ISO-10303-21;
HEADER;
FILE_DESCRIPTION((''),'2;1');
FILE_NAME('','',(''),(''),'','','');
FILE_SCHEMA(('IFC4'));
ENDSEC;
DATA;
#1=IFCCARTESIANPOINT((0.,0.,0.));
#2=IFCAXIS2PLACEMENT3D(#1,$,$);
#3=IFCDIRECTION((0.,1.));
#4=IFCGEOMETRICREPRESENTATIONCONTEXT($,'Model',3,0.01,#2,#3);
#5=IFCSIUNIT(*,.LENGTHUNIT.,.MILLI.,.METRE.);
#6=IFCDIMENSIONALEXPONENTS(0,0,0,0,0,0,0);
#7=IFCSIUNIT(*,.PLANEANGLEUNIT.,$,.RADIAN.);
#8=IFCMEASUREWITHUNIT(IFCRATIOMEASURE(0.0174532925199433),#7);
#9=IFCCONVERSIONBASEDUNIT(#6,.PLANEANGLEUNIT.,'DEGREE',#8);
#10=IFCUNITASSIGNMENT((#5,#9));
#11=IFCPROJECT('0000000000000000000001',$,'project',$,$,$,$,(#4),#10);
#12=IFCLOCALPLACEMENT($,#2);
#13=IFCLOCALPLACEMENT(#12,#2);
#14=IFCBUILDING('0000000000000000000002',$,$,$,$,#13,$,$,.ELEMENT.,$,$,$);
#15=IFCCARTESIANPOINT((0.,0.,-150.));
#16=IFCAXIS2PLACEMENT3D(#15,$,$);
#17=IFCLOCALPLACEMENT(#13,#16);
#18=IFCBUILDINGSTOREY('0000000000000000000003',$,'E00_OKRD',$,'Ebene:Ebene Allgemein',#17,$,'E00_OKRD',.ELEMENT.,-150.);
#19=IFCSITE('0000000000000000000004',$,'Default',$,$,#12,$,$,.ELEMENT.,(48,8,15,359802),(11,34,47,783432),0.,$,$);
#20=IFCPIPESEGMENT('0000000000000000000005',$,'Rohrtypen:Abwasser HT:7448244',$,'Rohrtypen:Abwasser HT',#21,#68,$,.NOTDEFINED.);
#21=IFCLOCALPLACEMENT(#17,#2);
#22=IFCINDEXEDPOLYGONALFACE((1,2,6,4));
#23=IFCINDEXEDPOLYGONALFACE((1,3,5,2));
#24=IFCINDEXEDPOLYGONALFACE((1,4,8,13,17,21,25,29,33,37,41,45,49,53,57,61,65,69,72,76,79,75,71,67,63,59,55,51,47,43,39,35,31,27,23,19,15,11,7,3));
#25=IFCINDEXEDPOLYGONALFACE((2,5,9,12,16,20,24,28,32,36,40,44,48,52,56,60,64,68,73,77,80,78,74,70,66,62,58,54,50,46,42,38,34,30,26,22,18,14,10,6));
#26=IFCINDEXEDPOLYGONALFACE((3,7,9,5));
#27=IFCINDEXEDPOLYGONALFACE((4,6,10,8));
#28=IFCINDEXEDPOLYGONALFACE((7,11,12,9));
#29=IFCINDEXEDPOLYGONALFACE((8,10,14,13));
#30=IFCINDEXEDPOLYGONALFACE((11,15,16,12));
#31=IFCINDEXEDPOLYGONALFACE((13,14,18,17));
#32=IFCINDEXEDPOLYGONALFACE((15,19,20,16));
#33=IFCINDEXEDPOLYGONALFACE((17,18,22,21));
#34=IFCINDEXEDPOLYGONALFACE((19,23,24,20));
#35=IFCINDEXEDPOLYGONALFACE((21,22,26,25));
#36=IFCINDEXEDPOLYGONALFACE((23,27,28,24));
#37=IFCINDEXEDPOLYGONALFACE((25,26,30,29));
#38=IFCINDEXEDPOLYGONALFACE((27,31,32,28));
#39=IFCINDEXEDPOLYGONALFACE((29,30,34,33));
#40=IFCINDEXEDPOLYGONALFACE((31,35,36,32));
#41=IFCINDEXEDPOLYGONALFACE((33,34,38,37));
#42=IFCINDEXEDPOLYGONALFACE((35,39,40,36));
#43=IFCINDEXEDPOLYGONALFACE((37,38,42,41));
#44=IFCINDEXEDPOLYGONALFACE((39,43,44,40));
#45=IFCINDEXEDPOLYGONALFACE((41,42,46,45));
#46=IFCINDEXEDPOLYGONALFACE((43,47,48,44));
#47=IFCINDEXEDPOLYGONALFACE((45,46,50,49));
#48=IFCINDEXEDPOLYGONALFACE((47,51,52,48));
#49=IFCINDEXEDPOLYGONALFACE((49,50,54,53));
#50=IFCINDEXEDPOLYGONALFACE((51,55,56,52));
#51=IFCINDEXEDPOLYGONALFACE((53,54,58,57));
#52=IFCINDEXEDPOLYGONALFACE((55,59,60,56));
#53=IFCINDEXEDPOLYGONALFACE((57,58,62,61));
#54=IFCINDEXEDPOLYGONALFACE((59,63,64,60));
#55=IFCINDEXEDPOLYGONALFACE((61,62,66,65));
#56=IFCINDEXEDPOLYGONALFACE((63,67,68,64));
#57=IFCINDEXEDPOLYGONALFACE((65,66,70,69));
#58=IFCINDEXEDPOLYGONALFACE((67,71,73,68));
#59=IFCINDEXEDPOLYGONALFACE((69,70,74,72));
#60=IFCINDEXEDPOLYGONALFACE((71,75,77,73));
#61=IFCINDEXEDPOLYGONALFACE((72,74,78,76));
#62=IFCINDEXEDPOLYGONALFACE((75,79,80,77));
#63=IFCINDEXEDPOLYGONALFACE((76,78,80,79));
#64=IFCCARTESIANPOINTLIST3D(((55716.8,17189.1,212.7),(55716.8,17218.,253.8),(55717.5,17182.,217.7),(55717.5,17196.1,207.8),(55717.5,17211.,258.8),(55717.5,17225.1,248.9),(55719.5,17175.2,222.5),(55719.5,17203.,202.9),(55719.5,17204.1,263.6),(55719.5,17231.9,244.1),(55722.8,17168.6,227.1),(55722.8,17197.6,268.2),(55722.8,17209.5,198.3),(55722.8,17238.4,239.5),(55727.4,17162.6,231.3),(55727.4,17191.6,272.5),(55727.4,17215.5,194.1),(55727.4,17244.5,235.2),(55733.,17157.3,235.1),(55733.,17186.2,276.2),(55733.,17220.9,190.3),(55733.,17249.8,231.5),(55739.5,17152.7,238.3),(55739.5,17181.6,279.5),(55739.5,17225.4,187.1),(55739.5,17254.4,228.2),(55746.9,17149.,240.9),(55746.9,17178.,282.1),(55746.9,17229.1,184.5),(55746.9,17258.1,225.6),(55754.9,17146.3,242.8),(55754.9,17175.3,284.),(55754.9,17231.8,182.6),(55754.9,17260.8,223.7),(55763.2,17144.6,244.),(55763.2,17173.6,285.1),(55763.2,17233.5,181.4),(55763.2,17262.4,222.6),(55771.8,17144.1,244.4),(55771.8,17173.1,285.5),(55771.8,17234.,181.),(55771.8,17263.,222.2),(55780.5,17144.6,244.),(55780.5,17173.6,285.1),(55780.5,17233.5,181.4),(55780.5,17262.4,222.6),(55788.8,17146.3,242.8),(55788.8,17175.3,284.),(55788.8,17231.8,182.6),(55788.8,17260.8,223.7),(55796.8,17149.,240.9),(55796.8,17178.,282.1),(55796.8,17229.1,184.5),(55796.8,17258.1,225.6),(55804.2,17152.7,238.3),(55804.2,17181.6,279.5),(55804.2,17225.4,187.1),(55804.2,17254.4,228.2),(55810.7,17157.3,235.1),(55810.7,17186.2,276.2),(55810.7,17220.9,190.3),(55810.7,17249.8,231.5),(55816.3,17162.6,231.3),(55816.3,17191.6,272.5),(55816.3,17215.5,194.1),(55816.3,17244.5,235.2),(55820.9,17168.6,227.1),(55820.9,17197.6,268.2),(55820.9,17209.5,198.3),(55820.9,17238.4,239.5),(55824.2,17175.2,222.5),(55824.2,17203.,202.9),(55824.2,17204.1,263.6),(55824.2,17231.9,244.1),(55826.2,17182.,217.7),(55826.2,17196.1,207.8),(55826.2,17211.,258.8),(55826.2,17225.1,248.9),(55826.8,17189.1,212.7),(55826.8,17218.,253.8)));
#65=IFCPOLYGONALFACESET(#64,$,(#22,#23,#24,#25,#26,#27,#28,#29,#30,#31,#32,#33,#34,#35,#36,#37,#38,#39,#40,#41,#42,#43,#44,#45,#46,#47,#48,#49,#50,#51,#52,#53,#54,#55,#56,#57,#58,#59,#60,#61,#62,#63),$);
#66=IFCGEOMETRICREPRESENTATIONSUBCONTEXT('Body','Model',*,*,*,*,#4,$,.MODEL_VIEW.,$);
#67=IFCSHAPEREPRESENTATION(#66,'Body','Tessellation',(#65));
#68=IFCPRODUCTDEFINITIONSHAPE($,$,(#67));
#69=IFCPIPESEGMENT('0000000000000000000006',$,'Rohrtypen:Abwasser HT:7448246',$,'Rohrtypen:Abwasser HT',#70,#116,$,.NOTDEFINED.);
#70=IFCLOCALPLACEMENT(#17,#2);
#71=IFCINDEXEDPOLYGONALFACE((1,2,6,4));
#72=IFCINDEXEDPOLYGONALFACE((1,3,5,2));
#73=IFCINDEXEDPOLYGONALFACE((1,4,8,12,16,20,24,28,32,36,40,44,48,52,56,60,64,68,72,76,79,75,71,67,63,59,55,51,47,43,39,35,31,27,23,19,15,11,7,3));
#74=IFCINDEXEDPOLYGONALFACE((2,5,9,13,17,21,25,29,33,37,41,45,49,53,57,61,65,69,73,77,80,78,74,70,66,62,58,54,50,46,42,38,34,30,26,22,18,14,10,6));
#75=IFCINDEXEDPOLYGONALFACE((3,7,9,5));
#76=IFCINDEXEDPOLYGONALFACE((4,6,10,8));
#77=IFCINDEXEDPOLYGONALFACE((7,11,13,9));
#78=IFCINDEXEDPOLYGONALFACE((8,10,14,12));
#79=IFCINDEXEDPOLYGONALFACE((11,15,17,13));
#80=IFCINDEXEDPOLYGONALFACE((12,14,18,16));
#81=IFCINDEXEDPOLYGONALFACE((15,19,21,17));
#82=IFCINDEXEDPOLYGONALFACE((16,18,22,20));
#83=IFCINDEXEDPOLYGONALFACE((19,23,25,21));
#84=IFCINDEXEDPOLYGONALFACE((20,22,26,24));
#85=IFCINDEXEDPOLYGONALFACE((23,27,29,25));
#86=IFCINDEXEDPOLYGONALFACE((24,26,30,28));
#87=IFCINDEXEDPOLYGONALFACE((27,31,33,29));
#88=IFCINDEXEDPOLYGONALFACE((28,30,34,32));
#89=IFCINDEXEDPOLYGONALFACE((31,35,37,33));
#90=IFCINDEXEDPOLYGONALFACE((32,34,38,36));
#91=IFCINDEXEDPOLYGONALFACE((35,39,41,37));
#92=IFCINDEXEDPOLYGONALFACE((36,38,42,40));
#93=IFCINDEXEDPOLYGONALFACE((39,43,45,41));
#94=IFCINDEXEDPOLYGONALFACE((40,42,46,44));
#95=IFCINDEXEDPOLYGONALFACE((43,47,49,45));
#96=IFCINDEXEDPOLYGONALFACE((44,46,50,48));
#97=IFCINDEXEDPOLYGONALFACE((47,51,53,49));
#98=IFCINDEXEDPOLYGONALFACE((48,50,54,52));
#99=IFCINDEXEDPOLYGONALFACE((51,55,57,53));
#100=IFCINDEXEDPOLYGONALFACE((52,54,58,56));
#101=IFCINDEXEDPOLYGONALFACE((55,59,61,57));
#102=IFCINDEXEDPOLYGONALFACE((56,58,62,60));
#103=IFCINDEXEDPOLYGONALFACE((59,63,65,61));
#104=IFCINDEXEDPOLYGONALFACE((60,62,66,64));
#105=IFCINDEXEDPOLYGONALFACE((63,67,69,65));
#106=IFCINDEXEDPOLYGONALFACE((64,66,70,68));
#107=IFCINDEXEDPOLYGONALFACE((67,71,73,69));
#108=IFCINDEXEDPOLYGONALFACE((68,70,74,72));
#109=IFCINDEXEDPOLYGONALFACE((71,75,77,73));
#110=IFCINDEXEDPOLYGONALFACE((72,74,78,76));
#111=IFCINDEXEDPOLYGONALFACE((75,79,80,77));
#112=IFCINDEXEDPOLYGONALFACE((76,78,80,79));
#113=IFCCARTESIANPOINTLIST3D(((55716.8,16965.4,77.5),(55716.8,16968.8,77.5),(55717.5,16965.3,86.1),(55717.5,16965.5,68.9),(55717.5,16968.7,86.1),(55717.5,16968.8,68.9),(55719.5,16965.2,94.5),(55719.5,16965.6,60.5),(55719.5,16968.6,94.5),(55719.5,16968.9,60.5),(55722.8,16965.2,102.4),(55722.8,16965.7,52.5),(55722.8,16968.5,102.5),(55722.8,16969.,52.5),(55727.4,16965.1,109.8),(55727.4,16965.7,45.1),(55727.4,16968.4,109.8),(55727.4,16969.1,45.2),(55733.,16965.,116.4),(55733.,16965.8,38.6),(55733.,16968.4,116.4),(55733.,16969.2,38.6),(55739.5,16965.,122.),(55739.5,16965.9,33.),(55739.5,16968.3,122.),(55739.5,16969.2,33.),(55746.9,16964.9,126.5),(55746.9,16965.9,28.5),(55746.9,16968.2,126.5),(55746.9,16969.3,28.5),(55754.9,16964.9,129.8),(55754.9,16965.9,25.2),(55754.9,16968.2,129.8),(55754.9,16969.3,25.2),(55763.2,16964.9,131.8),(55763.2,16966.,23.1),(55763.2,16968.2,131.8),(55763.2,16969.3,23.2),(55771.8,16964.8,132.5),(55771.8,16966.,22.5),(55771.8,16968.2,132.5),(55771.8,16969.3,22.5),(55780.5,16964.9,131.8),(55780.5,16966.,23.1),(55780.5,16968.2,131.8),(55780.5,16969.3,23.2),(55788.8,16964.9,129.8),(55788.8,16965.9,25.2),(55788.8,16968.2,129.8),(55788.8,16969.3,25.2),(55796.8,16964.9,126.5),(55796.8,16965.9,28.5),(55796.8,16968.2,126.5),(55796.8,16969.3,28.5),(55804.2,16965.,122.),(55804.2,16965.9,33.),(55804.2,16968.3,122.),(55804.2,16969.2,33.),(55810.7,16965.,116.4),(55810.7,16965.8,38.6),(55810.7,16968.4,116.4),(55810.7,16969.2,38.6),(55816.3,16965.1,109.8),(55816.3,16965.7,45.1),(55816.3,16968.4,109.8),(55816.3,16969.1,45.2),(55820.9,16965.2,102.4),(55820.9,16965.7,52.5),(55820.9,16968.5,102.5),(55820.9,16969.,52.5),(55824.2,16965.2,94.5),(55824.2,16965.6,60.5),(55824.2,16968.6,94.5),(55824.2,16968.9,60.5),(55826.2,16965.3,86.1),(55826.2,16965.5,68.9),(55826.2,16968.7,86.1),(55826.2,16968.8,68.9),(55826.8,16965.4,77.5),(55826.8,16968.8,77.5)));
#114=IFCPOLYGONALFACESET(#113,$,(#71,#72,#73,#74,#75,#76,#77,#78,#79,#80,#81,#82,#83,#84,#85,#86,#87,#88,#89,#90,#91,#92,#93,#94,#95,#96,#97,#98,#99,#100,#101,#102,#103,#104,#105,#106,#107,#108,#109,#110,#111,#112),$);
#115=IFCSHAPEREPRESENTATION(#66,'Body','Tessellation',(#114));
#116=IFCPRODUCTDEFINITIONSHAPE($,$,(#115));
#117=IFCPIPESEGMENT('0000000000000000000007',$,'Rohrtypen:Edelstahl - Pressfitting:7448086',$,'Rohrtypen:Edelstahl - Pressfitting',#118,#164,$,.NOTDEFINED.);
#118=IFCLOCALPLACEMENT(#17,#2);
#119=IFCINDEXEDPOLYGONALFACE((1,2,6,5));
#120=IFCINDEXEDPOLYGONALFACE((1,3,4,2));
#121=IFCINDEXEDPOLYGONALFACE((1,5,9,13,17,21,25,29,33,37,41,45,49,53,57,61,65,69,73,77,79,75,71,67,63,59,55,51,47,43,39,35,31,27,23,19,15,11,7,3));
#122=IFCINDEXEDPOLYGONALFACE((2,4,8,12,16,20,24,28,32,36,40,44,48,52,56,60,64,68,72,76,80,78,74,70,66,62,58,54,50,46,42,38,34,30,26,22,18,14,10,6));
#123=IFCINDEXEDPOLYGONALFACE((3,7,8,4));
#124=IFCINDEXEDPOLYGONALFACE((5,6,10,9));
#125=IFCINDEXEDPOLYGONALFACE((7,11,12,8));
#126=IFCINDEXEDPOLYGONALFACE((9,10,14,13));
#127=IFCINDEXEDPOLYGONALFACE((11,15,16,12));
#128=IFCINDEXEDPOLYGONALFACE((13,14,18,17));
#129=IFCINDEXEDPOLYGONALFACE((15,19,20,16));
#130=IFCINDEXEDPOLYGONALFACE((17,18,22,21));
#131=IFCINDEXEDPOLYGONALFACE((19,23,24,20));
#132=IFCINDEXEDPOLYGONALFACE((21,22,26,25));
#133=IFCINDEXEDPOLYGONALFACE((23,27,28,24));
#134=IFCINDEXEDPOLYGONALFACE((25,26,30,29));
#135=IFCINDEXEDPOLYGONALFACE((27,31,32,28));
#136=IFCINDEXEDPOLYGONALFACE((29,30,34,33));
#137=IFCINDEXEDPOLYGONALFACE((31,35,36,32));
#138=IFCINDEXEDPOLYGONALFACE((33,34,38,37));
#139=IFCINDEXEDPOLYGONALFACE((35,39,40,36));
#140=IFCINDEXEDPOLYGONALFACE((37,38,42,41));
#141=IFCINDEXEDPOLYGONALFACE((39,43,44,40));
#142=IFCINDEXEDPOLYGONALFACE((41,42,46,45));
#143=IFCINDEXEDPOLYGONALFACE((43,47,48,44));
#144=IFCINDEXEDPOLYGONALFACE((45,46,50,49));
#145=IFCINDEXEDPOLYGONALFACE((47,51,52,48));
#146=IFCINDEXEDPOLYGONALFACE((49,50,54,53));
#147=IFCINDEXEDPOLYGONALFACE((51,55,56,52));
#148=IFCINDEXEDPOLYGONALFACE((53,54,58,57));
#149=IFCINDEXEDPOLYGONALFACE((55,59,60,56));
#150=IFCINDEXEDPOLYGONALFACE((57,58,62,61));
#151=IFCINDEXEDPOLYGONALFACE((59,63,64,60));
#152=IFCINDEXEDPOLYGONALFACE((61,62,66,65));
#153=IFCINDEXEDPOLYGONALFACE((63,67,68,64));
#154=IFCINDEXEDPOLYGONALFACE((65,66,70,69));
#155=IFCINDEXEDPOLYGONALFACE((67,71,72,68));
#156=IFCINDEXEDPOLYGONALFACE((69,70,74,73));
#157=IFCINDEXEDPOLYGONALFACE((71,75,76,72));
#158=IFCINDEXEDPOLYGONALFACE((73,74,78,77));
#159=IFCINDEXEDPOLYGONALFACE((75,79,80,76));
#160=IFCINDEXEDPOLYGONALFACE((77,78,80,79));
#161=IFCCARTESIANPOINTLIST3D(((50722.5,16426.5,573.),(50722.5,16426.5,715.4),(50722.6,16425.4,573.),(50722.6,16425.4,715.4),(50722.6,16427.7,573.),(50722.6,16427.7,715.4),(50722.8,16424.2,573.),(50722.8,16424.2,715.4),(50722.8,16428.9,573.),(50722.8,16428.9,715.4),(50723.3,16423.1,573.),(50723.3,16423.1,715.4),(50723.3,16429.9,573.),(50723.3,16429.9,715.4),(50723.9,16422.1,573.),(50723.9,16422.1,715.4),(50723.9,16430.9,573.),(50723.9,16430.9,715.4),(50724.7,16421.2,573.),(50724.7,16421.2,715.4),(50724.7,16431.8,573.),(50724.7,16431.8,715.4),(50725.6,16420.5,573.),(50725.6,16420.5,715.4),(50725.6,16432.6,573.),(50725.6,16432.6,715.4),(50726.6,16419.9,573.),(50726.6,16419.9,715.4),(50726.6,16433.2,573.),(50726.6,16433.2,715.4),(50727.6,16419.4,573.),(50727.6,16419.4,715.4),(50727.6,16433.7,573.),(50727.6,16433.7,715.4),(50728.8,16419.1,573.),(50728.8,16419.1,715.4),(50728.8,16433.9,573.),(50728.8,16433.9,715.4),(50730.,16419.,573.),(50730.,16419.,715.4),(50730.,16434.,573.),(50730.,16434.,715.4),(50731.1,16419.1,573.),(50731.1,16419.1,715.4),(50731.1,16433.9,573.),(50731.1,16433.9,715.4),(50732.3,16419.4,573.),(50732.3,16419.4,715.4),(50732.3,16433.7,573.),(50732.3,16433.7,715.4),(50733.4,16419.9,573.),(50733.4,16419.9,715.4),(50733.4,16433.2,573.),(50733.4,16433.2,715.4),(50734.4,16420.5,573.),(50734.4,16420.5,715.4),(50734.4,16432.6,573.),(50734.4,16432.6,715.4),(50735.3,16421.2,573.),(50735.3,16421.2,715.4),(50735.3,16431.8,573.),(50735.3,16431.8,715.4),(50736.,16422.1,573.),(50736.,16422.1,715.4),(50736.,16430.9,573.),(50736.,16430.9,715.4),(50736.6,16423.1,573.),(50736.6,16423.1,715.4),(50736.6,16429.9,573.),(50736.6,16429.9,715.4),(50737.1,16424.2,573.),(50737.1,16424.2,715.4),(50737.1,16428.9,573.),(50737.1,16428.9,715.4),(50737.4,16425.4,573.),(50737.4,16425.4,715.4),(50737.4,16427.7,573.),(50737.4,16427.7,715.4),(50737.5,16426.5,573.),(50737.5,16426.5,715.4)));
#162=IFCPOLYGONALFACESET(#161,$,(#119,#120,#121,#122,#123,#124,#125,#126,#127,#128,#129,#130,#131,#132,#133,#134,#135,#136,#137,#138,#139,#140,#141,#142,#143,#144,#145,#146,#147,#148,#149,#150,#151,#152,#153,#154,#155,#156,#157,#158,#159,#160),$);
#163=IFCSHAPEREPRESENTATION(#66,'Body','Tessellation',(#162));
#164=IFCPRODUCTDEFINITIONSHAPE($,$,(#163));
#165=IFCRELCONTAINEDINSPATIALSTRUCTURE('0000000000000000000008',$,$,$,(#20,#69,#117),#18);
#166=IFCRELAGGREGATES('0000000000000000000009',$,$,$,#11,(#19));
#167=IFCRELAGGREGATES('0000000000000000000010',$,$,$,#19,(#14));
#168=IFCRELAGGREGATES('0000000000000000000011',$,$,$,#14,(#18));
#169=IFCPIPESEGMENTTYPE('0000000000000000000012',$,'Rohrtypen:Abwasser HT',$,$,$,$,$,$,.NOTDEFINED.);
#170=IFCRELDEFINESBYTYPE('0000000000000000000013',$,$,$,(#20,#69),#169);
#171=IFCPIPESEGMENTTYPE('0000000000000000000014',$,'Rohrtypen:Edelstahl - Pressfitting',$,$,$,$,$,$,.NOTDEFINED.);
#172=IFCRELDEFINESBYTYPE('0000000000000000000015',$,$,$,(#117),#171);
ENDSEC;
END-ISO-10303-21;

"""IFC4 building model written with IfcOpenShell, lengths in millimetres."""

from ifc_helpers import new_model, entity, si_unit, converted_unit, direction, frame, origin, place, context, subcontext, project, spatial, indexed_curve, outline, extrude, type_object, element, save


model = new_model("IFC4")

# Units and contexts
model_context = context("Model", 3, precision=0.01, world=origin(), true_north=direction((0.0, 1.0)))
body_context = subcontext(model_context, "Body", "Model", "MODEL_VIEW")
ifc_project = project(units=[si_unit("LENGTHUNIT", "METRE", prefix="MILLI"), converted_unit("PLANEANGLEUNIT", "DEGREE", entity("IfcRatioMeasure", 0.0174532925199433), si_unit("PLANEANGLEUNIT", "RADIAN"), dimensions=[0, 0, 0, 0, 0, 0, 0])], contexts=[model_context])

# Site, building, storey
site_placement = place(None, origin())
site = spatial("IfcSite", under=ifc_project, at=site_placement, Name="Default", CompositionType="ELEMENT", RefLatitude=(48, 8, 15, 359802), RefLongitude=(11, 34, 47, 783432), RefElevation=0.0)
building_placement = place(site_placement, origin())
building = spatial("IfcBuilding", under=site, at=building_placement, CompositionType="ELEMENT")
storey_placement = place(building_placement, frame((0.0, 0.0, -150.0)))
storey = spatial("IfcBuildingStorey", under=building, at=storey_placement, Name="E00_OKRD", ObjectType="Ebene:Ebene Allgemein", LongName="E00_OKRD", CompositionType="ELEMENT", Elevation=-150.0)

# Pipe segments
pipe_segment_type_1 = type_object("IfcPipeSegmentType", Name="Rohrtypen:Abwasser HT", PredefinedType="NOTDEFINED")
pipe_segment_1_placement = place(storey_placement, origin())
element("IfcPipeSegment", 1, at=pipe_segment_1_placement, inside=storey, type_object=pipe_segment_type_1, Name="Rohrtypen:Abwasser HT:7448244", ObjectType="Rohrtypen:Abwasser HT", PredefinedType="NOTDEFINED", context=body_context, shape_type="SweptSolid", body=[
    extrude(outline(indexed_curve([(55.0, 0.0), (54.3, 8.6), (52.3, 17.0), (49.0, 25.0), (44.5, 32.3), (38.9, 38.9), (32.3, 44.5), (25.0, 49.0), (17.0, 52.3), (8.6, 54.3), (0.0, 55.0), (-8.6, 54.3), (-17.0, 52.3), (-25.0, 49.0), (-32.3, 44.5), (-38.9, 38.9), (-44.5, 32.3), (-49.0, 25.0), (-52.3, 17.0), (-54.3, 8.6), (-55.0, 0.0), (-54.3, -8.6), (-52.3, -17.0), (-49.0, -25.0), (-44.5, -32.3), (-38.9, -38.9), (-32.3, -44.5), (-25.0, -49.0), (-17.0, -52.3), (-8.6, -54.3), (0.0, -55.0), (8.6, -54.3), (17.0, -52.3), (25.0, -49.0), (32.3, -44.5), (38.9, -38.9), (44.5, -32.3), (49.0, -25.0), (52.3, -17.0), (54.3, -8.6), (55.0, 0.0)], self_intersect=False)), frame((55771.8, 17189.1, 212.7), z_axis=(0.0, 0.575804, 0.817587), x_axis=(-1.0, 0.0, 0.0)), (0.0, 0.0, 1.0), 50.3),
])
pipe_segment_2_placement = place(storey_placement, origin())
element("IfcPipeSegment", 2, at=pipe_segment_2_placement, inside=storey, type_object=pipe_segment_type_1, Name="Rohrtypen:Abwasser HT:7448246", ObjectType="Rohrtypen:Abwasser HT", PredefinedType="NOTDEFINED", context=body_context, shape_type="SweptSolid", body=[
    extrude(outline(indexed_curve([(55.0, 0.0), (54.3, 8.6), (52.3, 17.0), (49.0, 25.0), (44.5, 32.3), (38.9, 38.9), (32.3, 44.5), (25.0, 49.0), (17.0, 52.3), (8.6, 54.3), (0.0, 55.0), (-8.6, 54.3), (-17.0, 52.3), (-25.0, 49.0), (-32.3, 44.5), (-38.9, 38.9), (-44.5, 32.3), (-49.0, 25.0), (-52.3, 17.0), (-54.3, 8.6), (-55.0, 0.0), (-54.3, -8.6), (-52.3, -17.0), (-49.0, -25.0), (-44.5, -32.3), (-38.9, -38.9), (-32.3, -44.5), (-25.0, -49.0), (-17.0, -52.3), (-8.6, -54.3), (0.0, -55.0), (8.6, -54.3), (17.0, -52.3), (25.0, -49.0), (32.3, -44.5), (38.9, -38.9), (44.5, -32.3), (49.0, -25.0), (52.3, -17.0), (54.3, -8.6), (55.0, 0.0)], self_intersect=False)), frame((55771.8, 16965.4, 77.5), z_axis=(0.0, 0.999947, 0.010286), x_axis=(-1.0, 0.0, 0.0)), (0.0, 0.0, 1.0), 3.3),
])
pipe_segment_type_2 = type_object("IfcPipeSegmentType", Name="Rohrtypen:Edelstahl - Pressfitting", PredefinedType="NOTDEFINED")
pipe_segment_3_placement = place(storey_placement, origin())
element("IfcPipeSegment", 3, at=pipe_segment_3_placement, inside=storey, type_object=pipe_segment_type_2, Name="Rohrtypen:Edelstahl - Pressfitting:7448086", ObjectType="Rohrtypen:Edelstahl - Pressfitting", PredefinedType="NOTDEFINED", context=body_context, shape_type="SweptSolid", body=[
    extrude(outline(indexed_curve([(7.5, 0.0), (7.4, 1.2), (7.1, 2.3), (6.7, 3.4), (6.1, 4.4), (5.3, 5.3), (4.4, 6.1), (3.4, 6.7), (2.3, 7.1), (1.2, 7.4), (0.0, 7.5), (-1.2, 7.4), (-2.3, 7.1), (-3.4, 6.7), (-4.4, 6.1), (-5.3, 5.3), (-6.1, 4.4), (-6.7, 3.4), (-7.1, 2.3), (-7.4, 1.2), (-7.5, 0.0), (-7.4, -1.2), (-7.1, -2.3), (-6.7, -3.4), (-6.1, -4.4), (-5.3, -5.3), (-4.4, -6.1), (-3.4, -6.7), (-2.3, -7.1), (-1.2, -7.4), (0.0, -7.5), (1.2, -7.4), (2.3, -7.1), (3.4, -6.7), (4.4, -6.1), (5.3, -5.3), (6.1, -4.4), (6.7, -3.4), (7.1, -2.3), (7.4, -1.2), (7.5, 0.0)], self_intersect=False)), frame((50730.0, 16426.5, 573.0), z_axis=(0.0, 0.0, 1.0), x_axis=(-1.0, 0.0, 0.0)), (0.0, 0.0, 1.0), 142.4),
])

save(model, "model.ifc")
